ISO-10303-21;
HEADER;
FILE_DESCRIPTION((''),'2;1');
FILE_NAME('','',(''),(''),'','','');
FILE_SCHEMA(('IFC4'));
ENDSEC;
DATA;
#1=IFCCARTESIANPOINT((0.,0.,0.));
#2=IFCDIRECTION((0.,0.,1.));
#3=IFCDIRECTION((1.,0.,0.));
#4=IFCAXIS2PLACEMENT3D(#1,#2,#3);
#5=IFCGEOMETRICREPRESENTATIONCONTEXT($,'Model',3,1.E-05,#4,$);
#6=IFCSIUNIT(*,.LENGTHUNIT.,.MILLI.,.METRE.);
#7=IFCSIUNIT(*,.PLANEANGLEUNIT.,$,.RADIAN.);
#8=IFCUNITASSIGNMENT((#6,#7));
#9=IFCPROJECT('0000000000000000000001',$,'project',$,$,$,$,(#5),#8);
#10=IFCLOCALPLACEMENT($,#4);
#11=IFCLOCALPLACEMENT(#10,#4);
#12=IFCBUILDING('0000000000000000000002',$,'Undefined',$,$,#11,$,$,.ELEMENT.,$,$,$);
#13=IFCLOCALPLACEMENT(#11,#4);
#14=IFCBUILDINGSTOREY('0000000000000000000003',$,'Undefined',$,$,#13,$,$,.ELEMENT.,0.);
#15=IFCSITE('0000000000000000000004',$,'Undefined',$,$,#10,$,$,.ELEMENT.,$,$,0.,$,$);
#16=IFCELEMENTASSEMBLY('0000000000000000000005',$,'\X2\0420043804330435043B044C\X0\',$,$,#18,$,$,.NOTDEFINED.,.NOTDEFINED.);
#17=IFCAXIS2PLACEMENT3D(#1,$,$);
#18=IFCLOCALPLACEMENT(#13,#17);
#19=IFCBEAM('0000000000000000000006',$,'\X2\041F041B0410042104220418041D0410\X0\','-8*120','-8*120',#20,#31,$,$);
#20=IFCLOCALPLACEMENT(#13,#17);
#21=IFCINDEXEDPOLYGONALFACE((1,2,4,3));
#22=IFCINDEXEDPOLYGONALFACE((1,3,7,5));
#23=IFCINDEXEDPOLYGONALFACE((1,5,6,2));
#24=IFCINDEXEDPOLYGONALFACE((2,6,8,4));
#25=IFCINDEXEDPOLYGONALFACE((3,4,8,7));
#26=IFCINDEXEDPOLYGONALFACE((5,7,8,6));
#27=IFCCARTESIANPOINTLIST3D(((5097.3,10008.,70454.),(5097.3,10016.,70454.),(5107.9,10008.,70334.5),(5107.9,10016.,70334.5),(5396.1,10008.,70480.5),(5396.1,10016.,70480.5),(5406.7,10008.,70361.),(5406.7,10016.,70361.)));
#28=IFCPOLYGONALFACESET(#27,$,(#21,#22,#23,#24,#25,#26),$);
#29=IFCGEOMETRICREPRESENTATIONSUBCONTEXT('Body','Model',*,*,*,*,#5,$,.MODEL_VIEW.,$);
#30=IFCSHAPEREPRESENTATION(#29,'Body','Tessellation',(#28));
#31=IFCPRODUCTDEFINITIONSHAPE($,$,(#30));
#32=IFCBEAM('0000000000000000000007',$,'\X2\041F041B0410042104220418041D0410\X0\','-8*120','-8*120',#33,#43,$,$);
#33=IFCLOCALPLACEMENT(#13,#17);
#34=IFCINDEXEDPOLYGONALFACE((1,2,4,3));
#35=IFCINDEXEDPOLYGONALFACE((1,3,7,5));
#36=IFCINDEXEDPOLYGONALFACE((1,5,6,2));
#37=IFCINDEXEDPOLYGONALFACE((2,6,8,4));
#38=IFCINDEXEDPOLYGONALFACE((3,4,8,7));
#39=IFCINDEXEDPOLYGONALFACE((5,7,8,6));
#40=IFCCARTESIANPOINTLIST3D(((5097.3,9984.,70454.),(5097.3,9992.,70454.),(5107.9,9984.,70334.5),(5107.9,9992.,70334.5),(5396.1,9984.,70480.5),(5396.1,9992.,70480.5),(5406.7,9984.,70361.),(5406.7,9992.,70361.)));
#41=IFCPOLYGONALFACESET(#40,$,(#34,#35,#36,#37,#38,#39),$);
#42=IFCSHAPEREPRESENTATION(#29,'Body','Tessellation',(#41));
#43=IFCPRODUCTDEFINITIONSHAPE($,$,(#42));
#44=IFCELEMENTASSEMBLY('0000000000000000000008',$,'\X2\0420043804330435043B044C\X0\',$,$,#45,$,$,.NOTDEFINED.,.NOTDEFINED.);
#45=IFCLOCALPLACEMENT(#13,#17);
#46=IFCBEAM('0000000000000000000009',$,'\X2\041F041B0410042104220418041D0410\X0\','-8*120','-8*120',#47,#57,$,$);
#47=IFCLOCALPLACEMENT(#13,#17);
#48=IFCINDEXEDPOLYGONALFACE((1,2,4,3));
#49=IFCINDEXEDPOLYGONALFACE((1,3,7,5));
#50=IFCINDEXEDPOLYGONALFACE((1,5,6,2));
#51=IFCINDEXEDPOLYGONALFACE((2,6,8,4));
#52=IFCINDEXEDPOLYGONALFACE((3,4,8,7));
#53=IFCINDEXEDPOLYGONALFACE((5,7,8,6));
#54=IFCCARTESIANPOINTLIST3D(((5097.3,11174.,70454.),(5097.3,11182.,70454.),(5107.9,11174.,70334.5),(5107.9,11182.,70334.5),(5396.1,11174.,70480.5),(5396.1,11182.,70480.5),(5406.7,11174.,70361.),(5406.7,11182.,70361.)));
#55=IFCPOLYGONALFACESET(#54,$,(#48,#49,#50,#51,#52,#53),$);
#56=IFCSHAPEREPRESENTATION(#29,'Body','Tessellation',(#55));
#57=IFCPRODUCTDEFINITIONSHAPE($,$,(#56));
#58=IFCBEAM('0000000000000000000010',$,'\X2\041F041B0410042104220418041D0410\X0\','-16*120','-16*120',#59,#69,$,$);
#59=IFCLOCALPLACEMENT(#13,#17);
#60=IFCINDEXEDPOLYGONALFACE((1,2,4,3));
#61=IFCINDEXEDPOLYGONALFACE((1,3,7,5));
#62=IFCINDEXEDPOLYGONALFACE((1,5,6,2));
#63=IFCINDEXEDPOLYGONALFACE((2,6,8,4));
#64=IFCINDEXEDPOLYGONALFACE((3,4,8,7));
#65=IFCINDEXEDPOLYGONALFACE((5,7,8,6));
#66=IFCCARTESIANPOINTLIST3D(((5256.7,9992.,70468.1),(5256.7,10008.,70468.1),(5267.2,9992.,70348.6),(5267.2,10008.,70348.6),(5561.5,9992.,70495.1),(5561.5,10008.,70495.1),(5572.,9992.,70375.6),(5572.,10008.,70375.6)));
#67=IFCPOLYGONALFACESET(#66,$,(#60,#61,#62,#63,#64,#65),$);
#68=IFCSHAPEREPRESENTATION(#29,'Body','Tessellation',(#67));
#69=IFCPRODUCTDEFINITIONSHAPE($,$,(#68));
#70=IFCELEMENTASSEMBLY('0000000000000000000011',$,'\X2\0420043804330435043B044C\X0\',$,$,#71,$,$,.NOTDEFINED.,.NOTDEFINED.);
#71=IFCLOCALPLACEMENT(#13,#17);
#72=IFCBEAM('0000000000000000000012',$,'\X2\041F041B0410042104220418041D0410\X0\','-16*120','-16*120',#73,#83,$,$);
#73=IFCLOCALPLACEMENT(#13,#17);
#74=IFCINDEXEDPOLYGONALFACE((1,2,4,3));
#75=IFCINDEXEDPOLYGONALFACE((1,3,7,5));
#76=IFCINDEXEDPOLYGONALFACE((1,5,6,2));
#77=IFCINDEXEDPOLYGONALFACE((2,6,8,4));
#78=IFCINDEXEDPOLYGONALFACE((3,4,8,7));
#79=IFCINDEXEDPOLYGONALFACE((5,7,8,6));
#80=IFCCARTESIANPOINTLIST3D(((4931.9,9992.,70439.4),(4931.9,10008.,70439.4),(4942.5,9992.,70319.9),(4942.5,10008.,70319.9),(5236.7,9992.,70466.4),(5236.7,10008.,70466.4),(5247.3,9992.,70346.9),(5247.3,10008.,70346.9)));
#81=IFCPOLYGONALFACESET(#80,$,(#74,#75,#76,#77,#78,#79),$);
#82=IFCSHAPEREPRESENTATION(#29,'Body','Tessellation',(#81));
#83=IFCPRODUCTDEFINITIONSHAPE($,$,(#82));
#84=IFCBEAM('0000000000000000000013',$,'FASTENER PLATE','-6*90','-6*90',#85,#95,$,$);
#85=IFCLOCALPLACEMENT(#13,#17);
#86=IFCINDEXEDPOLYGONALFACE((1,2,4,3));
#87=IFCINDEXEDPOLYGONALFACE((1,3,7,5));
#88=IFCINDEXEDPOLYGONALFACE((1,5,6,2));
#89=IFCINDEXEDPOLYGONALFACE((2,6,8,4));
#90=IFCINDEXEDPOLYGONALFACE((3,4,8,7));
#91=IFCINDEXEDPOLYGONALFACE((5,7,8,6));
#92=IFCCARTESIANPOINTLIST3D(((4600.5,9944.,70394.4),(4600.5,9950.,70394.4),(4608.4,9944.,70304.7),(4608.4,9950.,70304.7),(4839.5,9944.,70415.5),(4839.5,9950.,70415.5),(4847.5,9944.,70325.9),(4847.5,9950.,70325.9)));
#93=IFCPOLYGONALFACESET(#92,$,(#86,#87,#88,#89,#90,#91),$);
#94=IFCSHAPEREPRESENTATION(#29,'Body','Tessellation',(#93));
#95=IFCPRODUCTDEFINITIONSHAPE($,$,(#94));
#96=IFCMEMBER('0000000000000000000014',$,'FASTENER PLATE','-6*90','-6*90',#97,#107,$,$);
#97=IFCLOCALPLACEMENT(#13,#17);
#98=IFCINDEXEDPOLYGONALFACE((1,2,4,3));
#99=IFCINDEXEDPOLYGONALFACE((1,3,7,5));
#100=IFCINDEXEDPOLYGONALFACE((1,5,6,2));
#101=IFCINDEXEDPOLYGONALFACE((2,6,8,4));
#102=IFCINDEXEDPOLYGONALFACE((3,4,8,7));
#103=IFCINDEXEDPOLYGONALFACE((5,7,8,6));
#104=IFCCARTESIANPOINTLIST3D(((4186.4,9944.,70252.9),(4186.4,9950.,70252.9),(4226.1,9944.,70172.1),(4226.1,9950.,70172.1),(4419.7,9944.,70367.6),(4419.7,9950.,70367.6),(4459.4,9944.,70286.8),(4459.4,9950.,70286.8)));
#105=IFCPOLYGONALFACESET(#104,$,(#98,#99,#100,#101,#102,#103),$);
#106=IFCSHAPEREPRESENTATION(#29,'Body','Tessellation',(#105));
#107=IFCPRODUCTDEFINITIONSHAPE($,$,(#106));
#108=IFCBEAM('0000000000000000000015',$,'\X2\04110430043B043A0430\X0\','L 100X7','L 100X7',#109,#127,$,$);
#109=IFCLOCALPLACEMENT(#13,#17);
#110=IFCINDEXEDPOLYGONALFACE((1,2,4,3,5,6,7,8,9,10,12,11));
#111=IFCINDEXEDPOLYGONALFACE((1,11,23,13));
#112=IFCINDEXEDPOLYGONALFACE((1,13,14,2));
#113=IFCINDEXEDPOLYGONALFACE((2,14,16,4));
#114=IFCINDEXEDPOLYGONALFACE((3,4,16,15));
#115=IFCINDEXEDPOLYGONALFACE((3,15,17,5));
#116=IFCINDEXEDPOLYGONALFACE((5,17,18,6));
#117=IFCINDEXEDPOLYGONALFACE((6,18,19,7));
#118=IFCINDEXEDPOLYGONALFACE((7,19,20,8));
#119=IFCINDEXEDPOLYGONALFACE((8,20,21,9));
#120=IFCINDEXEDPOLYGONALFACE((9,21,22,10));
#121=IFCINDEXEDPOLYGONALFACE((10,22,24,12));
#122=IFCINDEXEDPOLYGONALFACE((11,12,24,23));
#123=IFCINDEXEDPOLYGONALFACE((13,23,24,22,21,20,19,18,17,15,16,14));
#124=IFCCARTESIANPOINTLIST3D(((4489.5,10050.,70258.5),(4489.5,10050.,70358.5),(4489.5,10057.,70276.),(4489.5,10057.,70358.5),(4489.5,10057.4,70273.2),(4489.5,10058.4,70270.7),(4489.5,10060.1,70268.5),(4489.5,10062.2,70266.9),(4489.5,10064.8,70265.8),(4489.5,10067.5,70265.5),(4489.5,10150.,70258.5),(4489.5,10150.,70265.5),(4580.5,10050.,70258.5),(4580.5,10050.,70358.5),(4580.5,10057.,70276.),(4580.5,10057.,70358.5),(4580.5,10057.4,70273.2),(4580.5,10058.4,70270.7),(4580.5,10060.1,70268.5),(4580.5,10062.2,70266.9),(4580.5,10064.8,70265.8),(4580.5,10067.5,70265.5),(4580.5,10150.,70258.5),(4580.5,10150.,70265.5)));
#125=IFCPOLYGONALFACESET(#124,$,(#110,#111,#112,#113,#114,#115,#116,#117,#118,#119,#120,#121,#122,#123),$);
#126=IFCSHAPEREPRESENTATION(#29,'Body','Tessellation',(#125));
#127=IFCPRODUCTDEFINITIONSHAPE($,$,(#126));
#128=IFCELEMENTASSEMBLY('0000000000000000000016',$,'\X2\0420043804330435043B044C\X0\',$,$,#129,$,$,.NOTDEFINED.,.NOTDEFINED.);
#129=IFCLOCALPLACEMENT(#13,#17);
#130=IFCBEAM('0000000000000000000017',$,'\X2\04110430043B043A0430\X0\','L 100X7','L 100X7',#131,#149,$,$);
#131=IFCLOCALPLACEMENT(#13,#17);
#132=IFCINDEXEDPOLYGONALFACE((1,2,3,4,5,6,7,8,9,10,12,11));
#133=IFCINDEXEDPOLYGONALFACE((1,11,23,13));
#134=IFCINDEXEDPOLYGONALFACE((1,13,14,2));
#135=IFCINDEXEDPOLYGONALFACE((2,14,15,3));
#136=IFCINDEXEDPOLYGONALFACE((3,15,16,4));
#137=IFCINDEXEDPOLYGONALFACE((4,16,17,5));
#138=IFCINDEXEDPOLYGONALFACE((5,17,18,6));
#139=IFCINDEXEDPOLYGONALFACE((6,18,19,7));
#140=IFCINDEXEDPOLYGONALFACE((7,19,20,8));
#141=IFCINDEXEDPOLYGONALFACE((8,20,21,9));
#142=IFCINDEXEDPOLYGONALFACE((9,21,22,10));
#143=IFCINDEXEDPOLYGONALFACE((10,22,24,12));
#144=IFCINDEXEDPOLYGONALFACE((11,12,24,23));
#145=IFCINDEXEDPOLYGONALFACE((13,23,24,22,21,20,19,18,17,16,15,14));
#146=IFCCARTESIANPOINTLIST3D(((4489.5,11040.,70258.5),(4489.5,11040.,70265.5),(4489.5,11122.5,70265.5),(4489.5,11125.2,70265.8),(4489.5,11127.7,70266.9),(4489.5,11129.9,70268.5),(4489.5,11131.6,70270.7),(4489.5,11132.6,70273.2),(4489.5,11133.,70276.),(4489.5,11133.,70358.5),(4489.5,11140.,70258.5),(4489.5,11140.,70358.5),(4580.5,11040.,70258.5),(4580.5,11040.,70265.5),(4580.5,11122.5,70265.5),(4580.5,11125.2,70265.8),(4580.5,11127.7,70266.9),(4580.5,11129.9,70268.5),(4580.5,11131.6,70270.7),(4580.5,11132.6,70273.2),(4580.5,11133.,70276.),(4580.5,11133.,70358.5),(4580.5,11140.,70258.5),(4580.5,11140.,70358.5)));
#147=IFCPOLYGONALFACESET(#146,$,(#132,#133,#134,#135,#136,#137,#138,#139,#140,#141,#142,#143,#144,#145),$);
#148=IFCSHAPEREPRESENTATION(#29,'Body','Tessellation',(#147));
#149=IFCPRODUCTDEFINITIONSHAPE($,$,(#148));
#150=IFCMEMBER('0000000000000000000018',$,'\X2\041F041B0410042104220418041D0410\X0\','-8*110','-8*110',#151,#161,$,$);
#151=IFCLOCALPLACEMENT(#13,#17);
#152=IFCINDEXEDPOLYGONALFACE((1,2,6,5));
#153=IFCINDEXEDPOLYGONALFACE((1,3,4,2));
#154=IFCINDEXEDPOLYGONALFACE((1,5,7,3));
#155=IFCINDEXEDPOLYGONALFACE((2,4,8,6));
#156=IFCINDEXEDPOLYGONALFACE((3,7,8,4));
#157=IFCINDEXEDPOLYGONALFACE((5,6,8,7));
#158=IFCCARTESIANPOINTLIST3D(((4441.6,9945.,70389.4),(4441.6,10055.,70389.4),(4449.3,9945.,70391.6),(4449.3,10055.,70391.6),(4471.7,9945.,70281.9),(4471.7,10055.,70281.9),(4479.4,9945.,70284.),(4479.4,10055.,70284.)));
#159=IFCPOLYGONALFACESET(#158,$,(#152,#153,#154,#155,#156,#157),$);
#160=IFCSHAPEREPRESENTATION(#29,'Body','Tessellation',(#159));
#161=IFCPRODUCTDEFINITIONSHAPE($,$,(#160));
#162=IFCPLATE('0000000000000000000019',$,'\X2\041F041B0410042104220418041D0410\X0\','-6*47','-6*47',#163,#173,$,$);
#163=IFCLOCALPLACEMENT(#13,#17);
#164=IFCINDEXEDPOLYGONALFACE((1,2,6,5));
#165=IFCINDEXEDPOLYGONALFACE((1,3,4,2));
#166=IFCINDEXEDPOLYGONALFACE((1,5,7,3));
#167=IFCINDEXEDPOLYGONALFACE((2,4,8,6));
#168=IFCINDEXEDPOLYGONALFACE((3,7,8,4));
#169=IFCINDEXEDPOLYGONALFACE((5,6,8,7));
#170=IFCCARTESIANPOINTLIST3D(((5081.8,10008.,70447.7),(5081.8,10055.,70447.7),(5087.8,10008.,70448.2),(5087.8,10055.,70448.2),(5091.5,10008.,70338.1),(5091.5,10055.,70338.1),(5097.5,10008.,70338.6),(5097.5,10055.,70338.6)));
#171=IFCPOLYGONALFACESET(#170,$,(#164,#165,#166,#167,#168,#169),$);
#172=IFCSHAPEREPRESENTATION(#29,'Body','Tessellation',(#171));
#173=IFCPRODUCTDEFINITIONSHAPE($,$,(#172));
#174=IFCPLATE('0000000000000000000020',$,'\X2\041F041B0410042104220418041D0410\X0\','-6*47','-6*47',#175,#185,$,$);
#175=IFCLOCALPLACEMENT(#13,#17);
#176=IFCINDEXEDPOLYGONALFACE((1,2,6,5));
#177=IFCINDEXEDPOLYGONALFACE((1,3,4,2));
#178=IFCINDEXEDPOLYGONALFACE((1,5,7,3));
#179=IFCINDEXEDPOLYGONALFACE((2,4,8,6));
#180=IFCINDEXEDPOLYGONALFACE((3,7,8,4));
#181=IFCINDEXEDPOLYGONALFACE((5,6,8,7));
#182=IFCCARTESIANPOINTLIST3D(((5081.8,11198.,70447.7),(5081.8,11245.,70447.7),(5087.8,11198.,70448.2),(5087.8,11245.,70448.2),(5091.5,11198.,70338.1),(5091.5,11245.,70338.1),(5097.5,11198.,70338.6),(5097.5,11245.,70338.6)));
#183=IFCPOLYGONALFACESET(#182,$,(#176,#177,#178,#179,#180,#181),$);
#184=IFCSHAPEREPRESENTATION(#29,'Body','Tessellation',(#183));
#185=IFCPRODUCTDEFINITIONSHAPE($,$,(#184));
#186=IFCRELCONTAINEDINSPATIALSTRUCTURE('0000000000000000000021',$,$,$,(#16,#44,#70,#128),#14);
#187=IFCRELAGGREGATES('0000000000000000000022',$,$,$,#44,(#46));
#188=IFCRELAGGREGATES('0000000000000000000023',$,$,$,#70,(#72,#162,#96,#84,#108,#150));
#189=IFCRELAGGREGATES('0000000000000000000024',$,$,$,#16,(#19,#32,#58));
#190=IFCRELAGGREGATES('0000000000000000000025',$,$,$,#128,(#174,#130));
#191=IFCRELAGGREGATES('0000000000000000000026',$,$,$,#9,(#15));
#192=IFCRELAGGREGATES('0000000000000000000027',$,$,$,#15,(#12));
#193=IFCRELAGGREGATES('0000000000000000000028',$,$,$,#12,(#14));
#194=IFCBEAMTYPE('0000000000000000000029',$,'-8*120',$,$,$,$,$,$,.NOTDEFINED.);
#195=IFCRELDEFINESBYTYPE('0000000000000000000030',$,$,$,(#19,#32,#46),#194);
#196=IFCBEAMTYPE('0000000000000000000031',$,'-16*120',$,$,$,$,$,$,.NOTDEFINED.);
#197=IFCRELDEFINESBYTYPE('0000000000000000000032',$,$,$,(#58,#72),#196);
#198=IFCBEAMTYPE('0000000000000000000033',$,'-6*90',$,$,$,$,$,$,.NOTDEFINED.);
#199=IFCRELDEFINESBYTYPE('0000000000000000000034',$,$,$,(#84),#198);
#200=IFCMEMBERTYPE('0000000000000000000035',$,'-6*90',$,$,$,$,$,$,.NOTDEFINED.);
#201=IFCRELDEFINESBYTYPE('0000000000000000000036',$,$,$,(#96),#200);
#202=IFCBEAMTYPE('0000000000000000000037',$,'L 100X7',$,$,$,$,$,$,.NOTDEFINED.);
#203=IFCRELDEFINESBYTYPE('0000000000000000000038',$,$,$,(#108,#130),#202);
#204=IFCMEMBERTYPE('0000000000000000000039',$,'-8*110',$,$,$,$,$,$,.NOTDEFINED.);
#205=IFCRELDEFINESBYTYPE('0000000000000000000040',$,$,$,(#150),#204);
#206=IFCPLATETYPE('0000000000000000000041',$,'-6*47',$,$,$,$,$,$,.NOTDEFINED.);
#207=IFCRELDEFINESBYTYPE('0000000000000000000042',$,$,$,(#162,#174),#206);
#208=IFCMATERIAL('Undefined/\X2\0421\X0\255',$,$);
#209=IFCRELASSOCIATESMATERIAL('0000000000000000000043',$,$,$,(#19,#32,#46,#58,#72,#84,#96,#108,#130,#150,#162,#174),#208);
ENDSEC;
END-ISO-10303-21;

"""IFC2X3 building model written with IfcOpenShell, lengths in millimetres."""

from ifc_helpers import new_model, si_unit, frame, origin_with_axes, origin_2d_with_axis, place, context, subcontext, project, spatial, polyline, rectangle, l_section, outline, extrude, boolean, material, type_object, element, aggregate, save


model = new_model("IFC2X3")

# Units and contexts
model_context = context("Model", 3, precision=1e-05, world=origin_with_axes())
body_context = subcontext(model_context, "Body", "Model", "MODEL_VIEW")
ifc_project = project(units=[si_unit("LENGTHUNIT", "METRE", prefix="MILLI"), si_unit("PLANEANGLEUNIT", "RADIAN")], contexts=[model_context])

# Site, building, storey
site_placement = place(None, origin_with_axes())
site = spatial("IfcSite", under=ifc_project, at=site_placement, Name="Undefined", CompositionType="ELEMENT", RefElevation=0.0)
building_placement = place(site_placement, origin_with_axes())
building = spatial("IfcBuilding", under=site, at=building_placement, Name="Undefined", CompositionType="ELEMENT")
storey_placement = place(building_placement, origin_with_axes())
storey = spatial("IfcBuildingStorey", under=building, at=storey_placement, Name="Undefined", CompositionType="ELEMENT", Elevation=0.0)

# Element assembly, beams
assembly_1_placement = place(storey_placement, origin_with_axes())
assembly_1 = element("IfcElementAssembly", 1, at=assembly_1_placement, inside=storey, Name="Ригель", AssemblyPlace="NOTDEFINED", PredefinedType="NOTDEFINED")
ifc_material_1 = material(Name="Undefined/С255")
beam_type_1 = type_object("IfcBeamType", Name="-8*120", PredefinedType="NOTDEFINED")
beam_1_placement = place(assembly_1_placement, frame((5102.6, 10012.0, 70394.3), z_axis=(0.088152, 0.0, -0.996107), x_axis=(0.996107, 0.0, 0.088152)))
beam_1 = element("IfcBeam", 2, at=beam_1_placement, type_object=beam_type_1, material=ifc_material_1, Name="ПЛАСТИНА", Description="-8*120", ObjectType="-8*120", context=body_context, shape_type="SweptSolid", body=[
    extrude(rectangle(XDim=8.0, YDim=120.0, at=origin_2d_with_axis()), frame((300.0, 0.0, 0.0), z_axis=(-1.0, 0.0, 0.0), x_axis=(0.0, -1.0, 0.0)), (0.0, 0.0, 1.0), 300.0),
])
beam_2_placement = place(assembly_1_placement, frame((5102.6, 9988.0, 70394.3), z_axis=(0.088152, 0.0, -0.996107), x_axis=(0.996107, 0.0, 0.088152)))
beam_2 = element("IfcBeam", 3, at=beam_2_placement, type_object=beam_type_1, material=ifc_material_1, Name="ПЛАСТИНА", Description="-8*120", ObjectType="-8*120", context=body_context, shape_type="SweptSolid", body=[
    extrude(rectangle(XDim=8.0, YDim=120.0, at=origin_2d_with_axis()), frame((300.0, 0.0, 0.0), z_axis=(-1.0, 0.0, 0.0), x_axis=(0.0, -1.0, 0.0)), (0.0, 0.0, 1.0), 300.0),
])

# Element assembly, beam
assembly_2_placement = place(storey_placement, origin_with_axes())
assembly_2 = element("IfcElementAssembly", 4, at=assembly_2_placement, inside=storey, Name="Ригель", AssemblyPlace="NOTDEFINED", PredefinedType="NOTDEFINED")
beam_3_placement = place(assembly_2_placement, frame((5102.6, 11178.0, 70394.3), z_axis=(0.088152, 0.0, -0.996107), x_axis=(0.996107, 0.0, 0.088152)))
beam_3 = element("IfcBeam", 5, at=beam_3_placement, type_object=beam_type_1, material=ifc_material_1, Name="ПЛАСТИНА", Description="-8*120", ObjectType="-8*120", context=body_context, shape_type="SweptSolid", body=[
    extrude(rectangle(XDim=8.0, YDim=120.0, at=origin_2d_with_axis()), frame((300.0, 0.0, 0.0), z_axis=(-1.0, 0.0, 0.0), x_axis=(0.0, -1.0, 0.0)), (0.0, 0.0, 1.0), 300.0),
])
aggregate(assembly_2, [beam_3])

# Beam
beam_type_2 = type_object("IfcBeamType", Name="-16*120", PredefinedType="NOTDEFINED")
beam_4_placement = place(assembly_1_placement, frame((5261.9, 10000.0, 70408.4), z_axis=(0.088152, 0.0, -0.996107), x_axis=(0.996107, 0.0, 0.088152)))
beam_4 = element("IfcBeam", 6, at=beam_4_placement, type_object=beam_type_2, material=ifc_material_1, Name="ПЛАСТИНА", Description="-16*120", ObjectType="-16*120", context=body_context, shape_type="SweptSolid", body=[
    extrude(rectangle(XDim=16.0, YDim=120.0, at=origin_2d_with_axis()), frame((306.0, 0.0, 0.0), z_axis=(-1.0, 0.0, 0.0), x_axis=(0.0, -1.0, 0.0)), (0.0, 0.0, 1.0), 306.0),
])

# Element assembly, beams, member
assembly_3_placement = place(storey_placement, origin_with_axes())
assembly_3 = element("IfcElementAssembly", 7, at=assembly_3_placement, inside=storey, Name="Ригель", AssemblyPlace="NOTDEFINED", PredefinedType="NOTDEFINED")
beam_5_placement = place(assembly_3_placement, frame((4937.2, 10000.0, 70379.6), z_axis=(0.088152, 0.0, -0.996107), x_axis=(0.996107, 0.0, 0.088152)))
beam_5 = element("IfcBeam", 8, at=beam_5_placement, type_object=beam_type_2, material=ifc_material_1, Name="ПЛАСТИНА", Description="-16*120", ObjectType="-16*120", context=body_context, shape_type="SweptSolid", body=[
    extrude(rectangle(XDim=16.0, YDim=120.0, at=origin_2d_with_axis()), frame((306.0, 0.0, 0.0), z_axis=(-1.0, 0.0, 0.0), x_axis=(0.0, -1.0, 0.0)), (0.0, 0.0, 1.0), 306.0),
])
beam_type_3 = type_object("IfcBeamType", Name="-6*90", PredefinedType="NOTDEFINED")
beam_6_placement = place(assembly_3_placement, frame((4843.5, 9947.0, 70370.7), z_axis=(-0.088152, 0.0, 0.996107), x_axis=(-0.996107, 0.0, -0.088152)))
beam_6 = element("IfcBeam", 9, at=beam_6_placement, type_object=beam_type_3, material=ifc_material_1, Name="FASTENER PLATE", Description="-6*90", ObjectType="-6*90", context=body_context, shape_type="SweptSolid", body=[
    extrude(rectangle(XDim=6.0, YDim=90.0, at=origin_2d_with_axis()), frame((240.0, 0.0, 0.0), z_axis=(-1.0, 0.0, 0.0), x_axis=(0.0, -1.0, 0.0)), (0.0, 0.0, 1.0), 240.0),
])
member_type_1 = type_object("IfcMemberType", Name="-6*90", PredefinedType="NOTDEFINED")
member_1_placement = place(assembly_3_placement, frame((4439.5, 9947.0, 70327.2), z_axis=(-0.441224, 0.0, 0.897397), x_axis=(-0.897397, 0.0, -0.441224)))
member_1 = element("IfcMember", 10, at=member_1_placement, type_object=member_type_1, material=ifc_material_1, Name="FASTENER PLATE", Description="-6*90", ObjectType="-6*90", context=body_context, shape_type="SweptSolid", body=[
    extrude(rectangle(XDim=6.0, YDim=90.0, at=origin_2d_with_axis()), frame((260.0, 0.0, 0.0), z_axis=(-1.0, 0.0, 0.0), x_axis=(0.0, -1.0, 0.0)), (0.0, 0.0, 1.0), 260.0),
])
beam_type_4 = type_object("IfcBeamType", Name="L 100X7", PredefinedType="NOTDEFINED")
beam_7_placement = place(assembly_3_placement, frame((4489.5, 10100.0, 70308.5), z_axis=(0.0, 1.0, 0.0), x_axis=(1.0, 0.0, 0.0)))
beam_7 = element("IfcBeam", 11, at=beam_7_placement, type_object=beam_type_4, material=ifc_material_1, Name="Балка", Description="L 100X7", ObjectType="L 100X7", context=body_context, shape_type="SweptSolid", body=[
    extrude(l_section(Depth=100.0, Width=100.0, Thickness=7.0, FilletRadius=10.5, at=origin_2d_with_axis()), frame((91.0, 0.0, 0.0), z_axis=(-1.0, 0.0, 0.0), x_axis=(0.0, -1.0, 0.0)), (0.0, 0.0, 1.0), 91.0),
])

# Element assembly, beam
assembly_4_placement = place(storey_placement, origin_with_axes())
assembly_4 = element("IfcElementAssembly", 12, at=assembly_4_placement, inside=storey, Name="Ригель", AssemblyPlace="NOTDEFINED", PredefinedType="NOTDEFINED")
beam_8_placement = place(assembly_4_placement, frame((4489.5, 11090.0, 70308.5), z_axis=(0.0, 0.0, 1.0), x_axis=(1.0, 0.0, 0.0)))
beam_8 = element("IfcBeam", 13, at=beam_8_placement, type_object=beam_type_4, material=ifc_material_1, Name="Балка", Description="L 100X7", ObjectType="L 100X7", context=body_context, shape_type="SweptSolid", body=[
    extrude(l_section(Depth=100.0, Width=100.0, Thickness=7.0, FilletRadius=10.5, at=origin_2d_with_axis()), frame((91.0, 0.0, 0.0), z_axis=(-1.0, 0.0, 0.0), x_axis=(0.0, -1.0, 0.0)), (0.0, 0.0, 1.0), 91.0),
])

# Member
member_type_2 = type_object("IfcMemberType", Name="-8*110", PredefinedType="NOTDEFINED")
member_2_placement = place(assembly_3_placement, frame((4475.6, 10000.0, 70282.9), z_axis=(0.0, -1.0, 0.0), x_axis=(-0.269248, 0.0, 0.963071)))
member_2 = element("IfcMember", 14, at=member_2_placement, type_object=member_type_2, material=ifc_material_1, Name="ПЛАСТИНА", Description="-8*110", ObjectType="-8*110", context=body_context, shape_type="SweptSolid", body=[
    extrude(rectangle(XDim=8.0, YDim=110.0, at=origin_2d_with_axis()), frame((111.7, 0.0, 0.0), z_axis=(-1.0, 0.0, 0.0), x_axis=(0.0, -1.0, 0.0)), (0.0, 0.0, 1.0), 111.7),
])

# Plates
plate_type_1 = type_object("IfcPlateType", Name="-6*47", PredefinedType="NOTDEFINED")
plate_1_placement = place(assembly_3_placement, frame((5084.8, 9945.0, 70447.9), z_axis=(0.996107, 0.0, 0.088152), x_axis=(0.088152, 0.0, -0.996107)))
plate_1 = element("IfcPlate", 15, at=plate_1_placement, type_object=plate_type_1, material=ifc_material_1, Name="ПЛАСТИНА", Description="-6*47", ObjectType="-6*47", context=body_context, shape_type="CSG", body=[
    boolean("DIFFERENCE", extrude(outline(polyline([(0.0, 0.0), (110.0, 0.0), (110.0, 110.0), (0.0, 110.0), (0.0, 0.0)])), frame((0.0, 0.0, -3.0), z_axis=(0.0, 0.0, 1.0), x_axis=(1.0, 0.0, 0.0)), (0.0, 0.0, 1.0), 6.0), extrude(rectangle(XDim=26.0, YDim=130.0, at=origin_2d_with_axis()), frame((55.0, -3.0, 0.0), z_axis=(0.0, 1.0, 0.0), x_axis=(0.0, 0.0, -1.0)), (0.0, 0.0, 1.0), 66.0)),
])
aggregate(assembly_3, [beam_5, plate_1, member_1, beam_6, beam_7, member_2])
plate_2_placement = place(assembly_4_placement, frame((5084.8, 11135.0, 70447.9), z_axis=(0.996107, 0.0, 0.088152), x_axis=(0.088152, 0.0, -0.996107)))
plate_2 = element("IfcPlate", 16, at=plate_2_placement, type_object=plate_type_1, material=ifc_material_1, Name="ПЛАСТИНА", Description="-6*47", ObjectType="-6*47", context=body_context, shape_type="CSG", body=[
    boolean("DIFFERENCE", extrude(outline(polyline([(0.0, 0.0), (110.0, 0.0), (110.0, 110.0), (0.0, 110.0), (0.0, 0.0)])), frame((0.0, 0.0, -3.0), z_axis=(0.0, 0.0, 1.0), x_axis=(1.0, 0.0, 0.0)), (0.0, 0.0, 1.0), 6.0), extrude(rectangle(XDim=26.0, YDim=130.0, at=origin_2d_with_axis()), frame((55.0, -3.0, 0.0), z_axis=(0.0, 1.0, 0.0), x_axis=(0.0, 0.0, -1.0)), (0.0, 0.0, 1.0), 66.0)),
])

aggregate(assembly_1, [beam_1, beam_2, beam_4])
aggregate(assembly_4, [plate_2, beam_8])

save(model, "model.ifc")
